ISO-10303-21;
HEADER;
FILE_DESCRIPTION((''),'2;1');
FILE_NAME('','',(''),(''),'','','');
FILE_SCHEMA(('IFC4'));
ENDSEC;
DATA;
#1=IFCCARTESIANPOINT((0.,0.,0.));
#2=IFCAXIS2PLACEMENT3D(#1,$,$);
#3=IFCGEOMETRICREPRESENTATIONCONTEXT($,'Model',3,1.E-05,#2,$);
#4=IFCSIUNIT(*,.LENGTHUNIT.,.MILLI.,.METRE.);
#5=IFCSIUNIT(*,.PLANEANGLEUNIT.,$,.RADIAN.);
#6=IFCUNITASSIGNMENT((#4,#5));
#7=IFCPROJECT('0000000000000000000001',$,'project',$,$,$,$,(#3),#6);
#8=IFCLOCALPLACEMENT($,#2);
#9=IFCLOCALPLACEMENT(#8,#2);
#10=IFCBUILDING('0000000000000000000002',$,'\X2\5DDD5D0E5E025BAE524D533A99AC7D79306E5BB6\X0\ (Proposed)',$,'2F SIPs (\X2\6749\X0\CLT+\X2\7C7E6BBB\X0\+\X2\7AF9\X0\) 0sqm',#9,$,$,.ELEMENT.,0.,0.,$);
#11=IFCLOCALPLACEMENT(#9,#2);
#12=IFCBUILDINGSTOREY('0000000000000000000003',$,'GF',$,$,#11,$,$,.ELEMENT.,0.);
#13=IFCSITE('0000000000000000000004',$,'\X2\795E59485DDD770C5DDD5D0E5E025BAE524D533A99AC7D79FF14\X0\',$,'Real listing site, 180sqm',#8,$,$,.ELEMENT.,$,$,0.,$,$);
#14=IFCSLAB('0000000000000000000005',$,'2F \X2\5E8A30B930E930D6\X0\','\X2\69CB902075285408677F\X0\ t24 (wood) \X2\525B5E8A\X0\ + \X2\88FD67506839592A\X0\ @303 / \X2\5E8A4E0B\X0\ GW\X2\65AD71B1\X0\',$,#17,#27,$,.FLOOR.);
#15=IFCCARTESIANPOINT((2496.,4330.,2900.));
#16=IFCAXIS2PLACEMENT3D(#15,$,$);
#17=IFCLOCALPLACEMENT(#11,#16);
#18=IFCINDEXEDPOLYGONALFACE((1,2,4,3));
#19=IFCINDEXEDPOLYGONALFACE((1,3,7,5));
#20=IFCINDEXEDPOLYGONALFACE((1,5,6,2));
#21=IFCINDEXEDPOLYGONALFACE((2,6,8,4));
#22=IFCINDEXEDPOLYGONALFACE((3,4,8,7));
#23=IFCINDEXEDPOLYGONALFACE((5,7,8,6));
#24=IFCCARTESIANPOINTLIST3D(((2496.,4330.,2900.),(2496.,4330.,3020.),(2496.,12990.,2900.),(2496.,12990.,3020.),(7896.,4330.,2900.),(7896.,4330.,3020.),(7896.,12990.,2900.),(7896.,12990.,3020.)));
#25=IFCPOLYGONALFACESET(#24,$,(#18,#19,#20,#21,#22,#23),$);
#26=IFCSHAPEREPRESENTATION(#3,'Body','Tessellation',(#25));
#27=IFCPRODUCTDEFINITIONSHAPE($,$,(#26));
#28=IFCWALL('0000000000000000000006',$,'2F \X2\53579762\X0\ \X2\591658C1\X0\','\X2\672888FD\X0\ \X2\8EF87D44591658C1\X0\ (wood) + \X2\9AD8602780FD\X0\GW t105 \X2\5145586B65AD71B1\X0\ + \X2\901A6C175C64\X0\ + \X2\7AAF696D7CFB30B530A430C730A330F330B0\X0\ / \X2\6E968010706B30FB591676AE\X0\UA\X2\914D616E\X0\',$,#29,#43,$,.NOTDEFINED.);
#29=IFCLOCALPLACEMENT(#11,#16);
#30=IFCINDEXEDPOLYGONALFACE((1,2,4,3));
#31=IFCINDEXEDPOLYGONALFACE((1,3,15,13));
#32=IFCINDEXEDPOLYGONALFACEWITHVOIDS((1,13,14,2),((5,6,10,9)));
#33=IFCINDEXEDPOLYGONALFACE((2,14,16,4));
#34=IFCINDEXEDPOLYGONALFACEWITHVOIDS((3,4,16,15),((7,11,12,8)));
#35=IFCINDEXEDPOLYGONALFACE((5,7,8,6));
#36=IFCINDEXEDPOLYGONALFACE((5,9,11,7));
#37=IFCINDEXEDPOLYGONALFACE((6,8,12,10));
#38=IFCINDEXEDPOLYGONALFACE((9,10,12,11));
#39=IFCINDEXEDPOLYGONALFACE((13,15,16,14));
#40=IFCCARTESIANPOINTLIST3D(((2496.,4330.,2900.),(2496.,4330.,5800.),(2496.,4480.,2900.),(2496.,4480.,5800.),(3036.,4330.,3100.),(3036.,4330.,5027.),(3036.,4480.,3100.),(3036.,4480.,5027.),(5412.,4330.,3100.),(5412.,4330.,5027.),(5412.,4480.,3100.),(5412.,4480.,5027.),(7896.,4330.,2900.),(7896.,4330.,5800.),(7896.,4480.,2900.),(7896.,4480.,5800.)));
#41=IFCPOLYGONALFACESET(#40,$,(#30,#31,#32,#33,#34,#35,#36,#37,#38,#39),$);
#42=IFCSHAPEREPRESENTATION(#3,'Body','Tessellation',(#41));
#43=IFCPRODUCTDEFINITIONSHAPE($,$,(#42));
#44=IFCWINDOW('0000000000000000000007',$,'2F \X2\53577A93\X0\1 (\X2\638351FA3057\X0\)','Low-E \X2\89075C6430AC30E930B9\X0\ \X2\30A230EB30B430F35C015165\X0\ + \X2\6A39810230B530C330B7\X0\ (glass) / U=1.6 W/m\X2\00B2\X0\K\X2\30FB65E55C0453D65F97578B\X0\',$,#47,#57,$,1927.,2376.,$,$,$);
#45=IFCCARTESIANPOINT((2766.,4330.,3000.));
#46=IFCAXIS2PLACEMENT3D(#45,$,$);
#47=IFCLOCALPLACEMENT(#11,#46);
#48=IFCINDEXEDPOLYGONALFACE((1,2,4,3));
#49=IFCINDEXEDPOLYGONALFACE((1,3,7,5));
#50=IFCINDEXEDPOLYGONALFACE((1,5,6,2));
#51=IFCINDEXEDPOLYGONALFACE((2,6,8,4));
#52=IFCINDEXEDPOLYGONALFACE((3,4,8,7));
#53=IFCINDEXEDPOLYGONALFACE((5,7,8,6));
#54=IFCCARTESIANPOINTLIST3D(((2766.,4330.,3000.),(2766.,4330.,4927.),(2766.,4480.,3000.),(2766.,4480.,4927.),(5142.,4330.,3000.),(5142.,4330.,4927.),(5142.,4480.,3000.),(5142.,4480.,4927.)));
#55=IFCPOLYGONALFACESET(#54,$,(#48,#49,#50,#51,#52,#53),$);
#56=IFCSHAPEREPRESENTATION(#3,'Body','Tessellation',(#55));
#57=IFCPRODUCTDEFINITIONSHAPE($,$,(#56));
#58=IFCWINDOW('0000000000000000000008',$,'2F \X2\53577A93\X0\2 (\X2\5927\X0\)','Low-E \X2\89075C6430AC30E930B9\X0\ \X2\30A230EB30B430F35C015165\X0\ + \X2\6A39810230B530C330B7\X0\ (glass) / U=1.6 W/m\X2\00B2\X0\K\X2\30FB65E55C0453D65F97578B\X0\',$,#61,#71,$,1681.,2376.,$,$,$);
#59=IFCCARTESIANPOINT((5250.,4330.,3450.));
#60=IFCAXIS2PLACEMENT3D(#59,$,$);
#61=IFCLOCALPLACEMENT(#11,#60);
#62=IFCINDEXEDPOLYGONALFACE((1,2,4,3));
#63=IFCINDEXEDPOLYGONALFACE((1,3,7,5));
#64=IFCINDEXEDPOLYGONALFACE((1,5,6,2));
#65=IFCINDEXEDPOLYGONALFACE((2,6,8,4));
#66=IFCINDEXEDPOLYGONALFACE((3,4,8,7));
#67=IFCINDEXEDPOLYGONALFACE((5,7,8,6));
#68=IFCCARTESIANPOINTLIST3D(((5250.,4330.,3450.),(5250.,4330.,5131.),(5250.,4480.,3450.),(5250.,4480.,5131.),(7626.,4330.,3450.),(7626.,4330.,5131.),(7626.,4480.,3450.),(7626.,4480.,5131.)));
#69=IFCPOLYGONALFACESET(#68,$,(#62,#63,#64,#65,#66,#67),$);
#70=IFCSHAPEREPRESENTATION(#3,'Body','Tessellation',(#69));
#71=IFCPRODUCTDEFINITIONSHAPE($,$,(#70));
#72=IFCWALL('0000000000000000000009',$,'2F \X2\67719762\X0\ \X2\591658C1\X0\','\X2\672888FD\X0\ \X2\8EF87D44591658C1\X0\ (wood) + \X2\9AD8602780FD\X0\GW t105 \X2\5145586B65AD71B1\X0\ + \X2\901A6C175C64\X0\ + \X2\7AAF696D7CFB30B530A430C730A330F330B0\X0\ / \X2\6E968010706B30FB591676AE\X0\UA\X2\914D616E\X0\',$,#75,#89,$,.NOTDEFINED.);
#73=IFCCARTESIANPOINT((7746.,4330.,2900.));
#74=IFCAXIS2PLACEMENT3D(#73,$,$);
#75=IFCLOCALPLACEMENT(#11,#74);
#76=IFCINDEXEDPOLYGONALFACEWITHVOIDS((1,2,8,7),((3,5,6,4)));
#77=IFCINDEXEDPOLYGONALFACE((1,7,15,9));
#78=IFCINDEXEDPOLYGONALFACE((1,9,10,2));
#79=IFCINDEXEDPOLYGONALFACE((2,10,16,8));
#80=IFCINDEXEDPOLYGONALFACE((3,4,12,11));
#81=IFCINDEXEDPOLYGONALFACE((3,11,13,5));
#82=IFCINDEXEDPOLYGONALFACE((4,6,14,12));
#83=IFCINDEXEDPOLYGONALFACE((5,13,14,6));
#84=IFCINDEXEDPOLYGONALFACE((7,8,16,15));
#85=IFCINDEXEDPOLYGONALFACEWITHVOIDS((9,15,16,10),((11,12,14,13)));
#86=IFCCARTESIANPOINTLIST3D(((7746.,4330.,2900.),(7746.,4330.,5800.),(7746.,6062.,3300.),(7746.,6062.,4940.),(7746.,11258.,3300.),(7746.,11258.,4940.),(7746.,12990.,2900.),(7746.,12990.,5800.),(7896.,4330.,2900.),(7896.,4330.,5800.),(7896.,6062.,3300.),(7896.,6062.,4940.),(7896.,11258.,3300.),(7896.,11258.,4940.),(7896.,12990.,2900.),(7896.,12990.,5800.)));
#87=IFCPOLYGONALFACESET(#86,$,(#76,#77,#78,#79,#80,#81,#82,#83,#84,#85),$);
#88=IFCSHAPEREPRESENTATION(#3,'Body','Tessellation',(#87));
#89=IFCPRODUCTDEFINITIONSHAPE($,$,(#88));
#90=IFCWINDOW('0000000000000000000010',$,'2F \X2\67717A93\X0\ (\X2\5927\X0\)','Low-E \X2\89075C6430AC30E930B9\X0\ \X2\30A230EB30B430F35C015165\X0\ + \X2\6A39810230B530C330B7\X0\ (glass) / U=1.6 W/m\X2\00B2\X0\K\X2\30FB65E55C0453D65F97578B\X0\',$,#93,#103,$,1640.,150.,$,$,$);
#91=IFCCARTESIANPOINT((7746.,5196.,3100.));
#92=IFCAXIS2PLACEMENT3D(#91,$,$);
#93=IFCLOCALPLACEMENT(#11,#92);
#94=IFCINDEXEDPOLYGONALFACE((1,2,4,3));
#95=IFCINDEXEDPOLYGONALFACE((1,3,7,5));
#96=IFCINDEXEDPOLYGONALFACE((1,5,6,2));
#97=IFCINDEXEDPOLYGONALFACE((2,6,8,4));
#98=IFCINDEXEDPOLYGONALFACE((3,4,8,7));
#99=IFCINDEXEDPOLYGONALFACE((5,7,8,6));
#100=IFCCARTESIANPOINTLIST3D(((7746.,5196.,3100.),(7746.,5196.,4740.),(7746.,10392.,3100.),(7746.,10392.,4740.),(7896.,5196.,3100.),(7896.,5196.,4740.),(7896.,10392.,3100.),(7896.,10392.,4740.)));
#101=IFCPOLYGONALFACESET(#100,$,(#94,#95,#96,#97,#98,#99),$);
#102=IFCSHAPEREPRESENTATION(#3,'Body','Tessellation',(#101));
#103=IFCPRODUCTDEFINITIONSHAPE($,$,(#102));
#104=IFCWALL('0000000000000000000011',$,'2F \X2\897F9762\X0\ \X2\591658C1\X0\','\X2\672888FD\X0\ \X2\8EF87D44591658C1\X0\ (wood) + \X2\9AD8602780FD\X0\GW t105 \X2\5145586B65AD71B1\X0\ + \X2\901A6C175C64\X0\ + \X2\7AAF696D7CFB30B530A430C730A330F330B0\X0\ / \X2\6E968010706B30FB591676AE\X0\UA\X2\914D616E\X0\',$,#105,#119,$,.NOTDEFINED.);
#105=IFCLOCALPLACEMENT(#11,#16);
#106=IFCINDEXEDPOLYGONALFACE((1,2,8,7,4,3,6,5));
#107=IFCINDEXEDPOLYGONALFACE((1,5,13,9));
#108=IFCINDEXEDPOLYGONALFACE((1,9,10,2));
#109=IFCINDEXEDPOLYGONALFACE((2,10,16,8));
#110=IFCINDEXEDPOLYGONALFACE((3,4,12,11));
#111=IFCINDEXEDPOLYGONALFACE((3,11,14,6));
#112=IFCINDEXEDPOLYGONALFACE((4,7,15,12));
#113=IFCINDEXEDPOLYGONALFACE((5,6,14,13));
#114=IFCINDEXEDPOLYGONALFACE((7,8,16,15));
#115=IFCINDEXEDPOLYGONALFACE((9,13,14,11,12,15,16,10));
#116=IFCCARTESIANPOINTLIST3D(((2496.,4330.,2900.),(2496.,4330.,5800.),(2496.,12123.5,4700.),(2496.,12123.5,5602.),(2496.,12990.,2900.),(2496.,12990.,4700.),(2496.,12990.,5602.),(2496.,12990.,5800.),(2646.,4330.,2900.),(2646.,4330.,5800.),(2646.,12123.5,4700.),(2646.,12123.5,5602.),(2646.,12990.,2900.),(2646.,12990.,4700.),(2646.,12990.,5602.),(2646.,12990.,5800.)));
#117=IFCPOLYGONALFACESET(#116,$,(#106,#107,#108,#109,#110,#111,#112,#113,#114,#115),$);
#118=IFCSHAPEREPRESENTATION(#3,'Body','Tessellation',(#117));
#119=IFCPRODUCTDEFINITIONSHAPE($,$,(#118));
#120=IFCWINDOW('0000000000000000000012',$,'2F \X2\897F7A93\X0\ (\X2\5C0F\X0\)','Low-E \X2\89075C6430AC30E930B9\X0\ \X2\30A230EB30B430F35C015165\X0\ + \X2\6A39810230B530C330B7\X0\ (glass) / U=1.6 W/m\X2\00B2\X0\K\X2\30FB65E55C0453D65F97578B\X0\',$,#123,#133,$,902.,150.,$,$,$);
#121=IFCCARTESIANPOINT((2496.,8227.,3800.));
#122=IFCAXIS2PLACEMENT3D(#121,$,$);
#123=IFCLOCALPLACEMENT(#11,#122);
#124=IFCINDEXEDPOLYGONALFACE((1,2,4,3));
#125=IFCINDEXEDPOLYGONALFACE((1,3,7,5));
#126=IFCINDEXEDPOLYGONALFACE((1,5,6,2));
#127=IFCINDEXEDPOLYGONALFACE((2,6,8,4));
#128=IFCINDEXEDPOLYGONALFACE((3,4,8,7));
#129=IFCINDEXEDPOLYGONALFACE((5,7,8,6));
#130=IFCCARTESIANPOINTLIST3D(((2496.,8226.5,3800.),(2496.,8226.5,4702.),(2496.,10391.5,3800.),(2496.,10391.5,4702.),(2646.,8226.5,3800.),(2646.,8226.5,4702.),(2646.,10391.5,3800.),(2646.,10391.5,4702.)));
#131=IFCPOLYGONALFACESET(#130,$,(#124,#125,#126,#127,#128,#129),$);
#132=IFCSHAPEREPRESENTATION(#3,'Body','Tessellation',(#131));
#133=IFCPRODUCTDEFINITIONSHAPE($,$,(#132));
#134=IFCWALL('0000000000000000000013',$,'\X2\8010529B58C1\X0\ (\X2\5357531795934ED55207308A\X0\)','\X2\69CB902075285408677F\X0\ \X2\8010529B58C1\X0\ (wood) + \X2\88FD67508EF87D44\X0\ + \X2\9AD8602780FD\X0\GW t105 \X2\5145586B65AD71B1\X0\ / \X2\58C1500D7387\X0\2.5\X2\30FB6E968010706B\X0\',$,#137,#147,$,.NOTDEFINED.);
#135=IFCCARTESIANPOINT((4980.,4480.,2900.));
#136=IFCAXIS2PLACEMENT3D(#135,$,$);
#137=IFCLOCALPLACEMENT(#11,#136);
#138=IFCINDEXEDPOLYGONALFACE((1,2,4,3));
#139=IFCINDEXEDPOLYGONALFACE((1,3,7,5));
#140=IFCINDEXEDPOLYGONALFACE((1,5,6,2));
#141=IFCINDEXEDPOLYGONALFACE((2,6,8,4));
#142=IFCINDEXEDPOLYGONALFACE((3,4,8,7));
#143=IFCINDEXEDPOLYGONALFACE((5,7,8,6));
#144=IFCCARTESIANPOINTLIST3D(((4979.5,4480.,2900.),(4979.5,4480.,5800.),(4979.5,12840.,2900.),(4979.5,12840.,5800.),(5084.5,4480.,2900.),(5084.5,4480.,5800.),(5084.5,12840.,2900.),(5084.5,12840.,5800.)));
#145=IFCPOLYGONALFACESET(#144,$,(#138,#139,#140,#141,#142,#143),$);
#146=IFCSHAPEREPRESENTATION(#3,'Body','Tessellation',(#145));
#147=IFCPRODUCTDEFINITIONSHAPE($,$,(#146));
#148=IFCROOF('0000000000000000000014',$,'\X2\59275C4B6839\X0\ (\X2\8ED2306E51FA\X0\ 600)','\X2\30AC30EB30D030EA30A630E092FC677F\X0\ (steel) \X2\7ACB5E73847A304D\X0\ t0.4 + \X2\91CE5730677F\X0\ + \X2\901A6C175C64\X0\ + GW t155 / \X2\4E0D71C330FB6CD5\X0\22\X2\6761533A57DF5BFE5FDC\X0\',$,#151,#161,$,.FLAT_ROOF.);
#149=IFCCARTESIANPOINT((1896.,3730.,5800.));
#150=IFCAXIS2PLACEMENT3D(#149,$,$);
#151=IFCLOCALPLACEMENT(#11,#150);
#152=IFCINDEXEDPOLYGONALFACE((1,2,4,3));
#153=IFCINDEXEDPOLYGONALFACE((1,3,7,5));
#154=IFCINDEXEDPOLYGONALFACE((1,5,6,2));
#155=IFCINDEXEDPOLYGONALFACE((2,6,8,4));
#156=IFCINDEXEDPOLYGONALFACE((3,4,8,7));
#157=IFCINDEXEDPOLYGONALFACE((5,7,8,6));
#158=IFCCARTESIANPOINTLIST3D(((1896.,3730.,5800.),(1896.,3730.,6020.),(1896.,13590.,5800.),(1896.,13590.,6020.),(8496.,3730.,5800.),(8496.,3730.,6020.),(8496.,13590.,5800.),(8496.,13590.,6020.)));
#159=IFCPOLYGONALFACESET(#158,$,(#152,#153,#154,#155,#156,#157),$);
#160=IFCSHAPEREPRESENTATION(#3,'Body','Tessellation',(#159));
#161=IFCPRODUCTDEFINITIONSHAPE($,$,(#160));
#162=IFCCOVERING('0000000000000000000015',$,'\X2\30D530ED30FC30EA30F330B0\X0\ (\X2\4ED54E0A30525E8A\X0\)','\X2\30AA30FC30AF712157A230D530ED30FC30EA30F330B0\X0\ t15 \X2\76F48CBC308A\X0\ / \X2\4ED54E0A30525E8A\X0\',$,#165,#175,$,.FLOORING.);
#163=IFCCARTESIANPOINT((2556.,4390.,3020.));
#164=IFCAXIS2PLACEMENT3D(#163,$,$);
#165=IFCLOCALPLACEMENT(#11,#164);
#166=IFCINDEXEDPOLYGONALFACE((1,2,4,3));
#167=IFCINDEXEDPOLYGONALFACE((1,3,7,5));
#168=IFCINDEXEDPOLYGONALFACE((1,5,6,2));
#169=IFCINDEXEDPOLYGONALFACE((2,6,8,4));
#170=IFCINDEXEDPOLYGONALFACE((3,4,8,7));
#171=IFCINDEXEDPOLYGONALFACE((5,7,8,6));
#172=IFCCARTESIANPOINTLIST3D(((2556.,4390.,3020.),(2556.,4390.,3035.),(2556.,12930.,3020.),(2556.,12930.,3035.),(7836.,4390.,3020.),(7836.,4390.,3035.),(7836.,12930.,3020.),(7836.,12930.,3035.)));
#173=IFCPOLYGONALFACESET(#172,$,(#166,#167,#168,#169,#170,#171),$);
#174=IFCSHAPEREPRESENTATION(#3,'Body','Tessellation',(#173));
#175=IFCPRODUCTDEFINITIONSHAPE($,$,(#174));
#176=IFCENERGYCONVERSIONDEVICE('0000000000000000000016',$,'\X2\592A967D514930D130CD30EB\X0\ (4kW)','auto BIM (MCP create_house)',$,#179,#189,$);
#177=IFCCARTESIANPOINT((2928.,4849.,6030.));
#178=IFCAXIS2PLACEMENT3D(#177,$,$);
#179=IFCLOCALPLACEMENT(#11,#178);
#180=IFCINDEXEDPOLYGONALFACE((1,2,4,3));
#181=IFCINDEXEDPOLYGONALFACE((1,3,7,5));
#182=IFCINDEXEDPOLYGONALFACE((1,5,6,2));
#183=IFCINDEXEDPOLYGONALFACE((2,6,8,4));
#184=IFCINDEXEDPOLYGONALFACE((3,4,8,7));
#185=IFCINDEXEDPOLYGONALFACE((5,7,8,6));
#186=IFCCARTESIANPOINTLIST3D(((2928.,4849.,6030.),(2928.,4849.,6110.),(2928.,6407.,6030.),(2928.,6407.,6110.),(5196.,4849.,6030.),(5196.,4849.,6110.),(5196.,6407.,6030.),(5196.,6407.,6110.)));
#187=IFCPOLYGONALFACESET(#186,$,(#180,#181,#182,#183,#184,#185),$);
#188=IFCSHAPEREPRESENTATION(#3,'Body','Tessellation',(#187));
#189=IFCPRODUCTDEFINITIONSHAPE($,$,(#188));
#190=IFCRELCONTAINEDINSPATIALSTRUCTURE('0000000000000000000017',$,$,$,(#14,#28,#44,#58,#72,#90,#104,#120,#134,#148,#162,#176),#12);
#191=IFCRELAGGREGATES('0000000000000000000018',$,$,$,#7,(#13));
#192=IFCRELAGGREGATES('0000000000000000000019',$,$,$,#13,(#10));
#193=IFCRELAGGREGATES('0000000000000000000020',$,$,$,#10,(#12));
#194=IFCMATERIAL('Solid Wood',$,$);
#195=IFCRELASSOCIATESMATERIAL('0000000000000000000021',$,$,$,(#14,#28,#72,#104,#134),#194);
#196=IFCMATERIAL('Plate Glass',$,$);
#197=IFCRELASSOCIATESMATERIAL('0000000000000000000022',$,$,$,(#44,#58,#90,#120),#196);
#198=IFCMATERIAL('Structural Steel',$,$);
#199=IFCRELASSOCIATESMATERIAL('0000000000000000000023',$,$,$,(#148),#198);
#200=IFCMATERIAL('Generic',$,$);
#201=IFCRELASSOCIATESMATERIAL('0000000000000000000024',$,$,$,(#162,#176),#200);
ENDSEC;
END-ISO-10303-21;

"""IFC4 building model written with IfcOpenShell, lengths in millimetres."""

from ifc_helpers import new_model, si_unit, frame, frame_2d, origin, place, context, project, spatial, rectangle, extrude, material, element, fill, save


model = new_model("IFC4")

# Units and contexts
model_context = context("Model", 3, precision=1e-05, world=origin())
ifc_project = project(units=[si_unit("LENGTHUNIT", "METRE", prefix="MILLI"), si_unit("PLANEANGLEUNIT", "RADIAN")], contexts=[model_context])

# Site, building, storey
site_placement = place(None, origin())
site = spatial("IfcSite", under=ifc_project, at=site_placement, Name="神奈川県川崎市宮前区馬絹４", ObjectType="Real listing site, 180sqm", CompositionType="ELEMENT", RefElevation=0.0)
building_placement = place(site_placement, origin())
building = spatial("IfcBuilding", under=site, at=building_placement, Name="川崎市宮前区馬絹の家 (Proposed)", ObjectType="2F SIPs (杉CLT+籾殻+竹) 0sqm", CompositionType="ELEMENT", ElevationOfRefHeight=0.0, ElevationOfTerrain=0.0)
storey_placement = place(building_placement, origin())
storey = spatial("IfcBuildingStorey", under=building, at=storey_placement, Name="GF", CompositionType="ELEMENT", Elevation=0.0)

# Slab
ifc_material_1 = material(Name="Solid Wood")
slab_placement = place(storey_placement, frame((2496.0, 4330.0, 2900.0)))
element("IfcSlab", 1, at=slab_placement, inside=storey, material=ifc_material_1, Name="2F 床スラブ", Description="構造用合板 t24 (wood) 剛床 + 製材根太 @303 / 床下 GW断熱", PredefinedType="FLOOR", context=model_context, shape_type="SweptSolid", body=[
    extrude(rectangle(XDim=5400.0, YDim=8660.0, at=frame_2d((2700.0, 4330.0))), frame((2496.0, 4330.0, 2900.0)), (0.0, 0.0, 1.0), 120.0),
])

# Wall, openings, windows
wall_1_placement = place(storey_placement, frame((2496.0, 4330.0, 2900.0)))
wall_1 = element("IfcWall", 2, at=wall_1_placement, inside=storey, material=ifc_material_1, Name="2F 南面 外壁", Description="木製 軸組外壁 (wood) + 高性能GW t105 充填断熱 + 通気層 + 窯業系サイディング / 準耐火・外皮UA配慮", PredefinedType="NOTDEFINED", context=model_context, shape_type="SweptSolid", body=[
    extrude(rectangle(XDim=5400.0, YDim=150.0, at=frame_2d((2700.0, 75.0))), frame((2496.0, 4330.0, 2900.0)), (0.0, 0.0, 1.0), 2900.0),
])
opening_1_placement = place(storey_placement, frame((2766.0, 4330.0, 3000.0)))
opening_1 = element("IfcOpeningElement", 3, at=opening_1_placement, cuts=wall_1, PredefinedType="NOTDEFINED", context=model_context, shape_type="SweptSolid", body=[
    extrude(rectangle(XDim=2376.0, YDim=150.0, at=frame_2d((1188.0, 75.0))), frame((2766.0, 4330.0, 3000.0)), (0.0, 0.0, 1.0), 1927.0),
])
opening_2_placement = place(storey_placement, frame((5250.0, 4330.0, 3450.0)))
opening_2 = element("IfcOpeningElement", 4, at=opening_2_placement, cuts=wall_1, PredefinedType="NOTDEFINED", context=model_context, shape_type="SweptSolid", body=[
    extrude(rectangle(XDim=2376.0, YDim=150.0, at=frame_2d((1188.0, 75.0))), frame((5250.0, 4330.0, 3450.0)), (0.0, 0.0, 1.0), 1681.0),
])
ifc_material_2 = material(Name="Plate Glass")
window_1_placement = place(storey_placement, frame((2766.0, 4330.0, 3000.0)))
window_1 = element("IfcWindow", 5, at=window_1_placement, inside=storey, material=ifc_material_2, Name="2F 南窓1 (掃出し)", Description="Low-E 複層ガラス アルゴン封入 + 樹脂サッシ (glass) / U=1.6 W/m²K・日射取得型", OverallHeight=1927.0, OverallWidth=2376.0, context=model_context, shape_type="SweptSolid", body=[
    extrude(rectangle(XDim=2376.0, YDim=150.0, at=frame_2d((1188.0, 75.0))), frame((2766.0, 4330.0, 3000.0)), (0.0, 0.0, 1.0), 1927.0),
])
fill(opening_1, window_1)
window_2_placement = place(storey_placement, frame((5250.0, 4330.0, 3450.0)))
window_2 = element("IfcWindow", 6, at=window_2_placement, inside=storey, material=ifc_material_2, Name="2F 南窓2 (大)", Description="Low-E 複層ガラス アルゴン封入 + 樹脂サッシ (glass) / U=1.6 W/m²K・日射取得型", OverallHeight=1681.0, OverallWidth=2376.0, context=model_context, shape_type="SweptSolid", body=[
    extrude(rectangle(XDim=2376.0, YDim=150.0, at=frame_2d((1188.0, 75.0))), frame((5250.0, 4330.0, 3450.0)), (0.0, 0.0, 1.0), 1681.0),
])
fill(opening_2, window_2)

# Walls, openings, windows
wall_2_placement = place(storey_placement, frame((7746.0, 4330.0, 2900.0)))
wall_2 = element("IfcWall", 7, at=wall_2_placement, inside=storey, material=ifc_material_1, Name="2F 東面 外壁", Description="木製 軸組外壁 (wood) + 高性能GW t105 充填断熱 + 通気層 + 窯業系サイディング / 準耐火・外皮UA配慮", PredefinedType="NOTDEFINED", context=model_context, shape_type="SweptSolid", body=[
    extrude(rectangle(XDim=150.0, YDim=8660.0, at=frame_2d((75.0, 4330.0))), frame((7746.0, 4330.0, 2900.0)), (0.0, 0.0, 1.0), 2900.0),
])
opening_3_placement = place(storey_placement, frame((7746.0, 5196.0, 3100.0)))
opening_3 = element("IfcOpeningElement", 8, at=opening_3_placement, cuts=wall_2, PredefinedType="NOTDEFINED", context=model_context, shape_type="SweptSolid", body=[
    extrude(rectangle(XDim=150.0, YDim=5196.0, at=frame_2d((75.0, 2598.0))), frame((7746.0, 5196.0, 3100.0)), (0.0, 0.0, 1.0), 1640.0),
])
window_3_placement = place(storey_placement, frame((7746.0, 5196.0, 3100.0)))
window_3 = element("IfcWindow", 9, at=window_3_placement, inside=storey, material=ifc_material_2, Name="2F 東窓 (大)", Description="Low-E 複層ガラス アルゴン封入 + 樹脂サッシ (glass) / U=1.6 W/m²K・日射取得型", OverallHeight=1640.0, OverallWidth=150.0, context=model_context, shape_type="SweptSolid", body=[
    extrude(rectangle(XDim=150.0, YDim=5196.0, at=frame_2d((75.0, 2598.0))), frame((7746.0, 5196.0, 3100.0)), (0.0, 0.0, 1.0), 1640.0),
])
fill(opening_3, window_3)
wall_3_placement = place(storey_placement, frame((2496.0, 4330.0, 2900.0)))
wall_3 = element("IfcWall", 10, at=wall_3_placement, inside=storey, material=ifc_material_1, Name="2F 西面 外壁", Description="木製 軸組外壁 (wood) + 高性能GW t105 充填断熱 + 通気層 + 窯業系サイディング / 準耐火・外皮UA配慮", PredefinedType="NOTDEFINED", context=model_context, shape_type="SweptSolid", body=[
    extrude(rectangle(XDim=150.0, YDim=8660.0, at=frame_2d((75.0, 4330.0))), frame((2496.0, 4330.0, 2900.0)), (0.0, 0.0, 1.0), 2900.0),
])
opening_4_placement = place(storey_placement, frame((2496.0, 8227.0, 3800.0)))
opening_4 = element("IfcOpeningElement", 11, at=opening_4_placement, cuts=wall_3, PredefinedType="NOTDEFINED", context=model_context, shape_type="SweptSolid", body=[
    extrude(rectangle(XDim=150.0, YDim=2165.0, at=frame_2d((75.0, 1082.0))), frame((2496.0, 8227.0, 3800.0)), (0.0, 0.0, 1.0), 902.0),
])
window_4_placement = place(storey_placement, frame((2496.0, 8227.0, 3800.0)))
window_4 = element("IfcWindow", 12, at=window_4_placement, inside=storey, material=ifc_material_2, Name="2F 西窓 (小)", Description="Low-E 複層ガラス アルゴン封入 + 樹脂サッシ (glass) / U=1.6 W/m²K・日射取得型", OverallHeight=902.0, OverallWidth=150.0, context=model_context, shape_type="SweptSolid", body=[
    extrude(rectangle(XDim=150.0, YDim=2165.0, at=frame_2d((75.0, 1082.0))), frame((2496.0, 8227.0, 3800.0)), (0.0, 0.0, 1.0), 902.0),
])
fill(opening_4, window_4)

# Wall
wall_4_placement = place(storey_placement, frame((4980.0, 4480.0, 2900.0)))
element("IfcWall", 13, at=wall_4_placement, inside=storey, material=ifc_material_1, Name="耐力壁 (南北間仕切り)", Description="構造用合板 耐力壁 (wood) + 製材軸組 + 高性能GW t105 充填断熱 / 壁倍率2.5・準耐火", PredefinedType="NOTDEFINED", context=model_context, shape_type="SweptSolid", body=[
    extrude(rectangle(XDim=105.0, YDim=8360.0, at=frame_2d((52.0, 4180.0))), frame((4980.0, 4480.0, 2900.0)), (0.0, 0.0, 1.0), 2900.0),
])

# Roof
ifc_material_3 = material(Name="Structural Steel")
roof_placement = place(storey_placement, frame((1896.0, 3730.0, 5800.0)))
element("IfcRoof", 14, at=roof_placement, inside=storey, material=ifc_material_3, Name="大屋根 (軒の出 600)", Description="ガルバリウム鋼板 (steel) 立平葺き t0.4 + 野地板 + 通気層 + GW t155 / 不燃・法22条区域対応", PredefinedType="FLAT_ROOF", context=model_context, shape_type="SweptSolid", body=[
    extrude(rectangle(XDim=6600.0, YDim=9860.0, at=frame_2d((3300.0, 4930.0))), frame((1896.0, 3730.0, 5800.0)), (0.0, 0.0, 1.0), 220.0),
])

# Covering
ifc_material_4 = material(Name="Generic")
covering_placement = place(storey_placement, frame((2556.0, 4390.0, 3020.0)))
element("IfcCovering", 15, at=covering_placement, inside=storey, material=ifc_material_4, Name="フローリング (仕上げ床)", Description="オーク無垢フローリング t15 直貼り / 仕上げ床", PredefinedType="FLOORING", context=model_context, shape_type="SweptSolid", body=[
    extrude(rectangle(XDim=5280.0, YDim=8540.0, at=frame_2d((2640.0, 4270.0))), frame((2556.0, 4390.0, 3020.0)), (0.0, 0.0, 1.0), 15.0),
])

# Energy conversion device
energy_conversion_device_placement = place(storey_placement, frame((2928.0, 4849.0, 6030.0)))
element("IfcEnergyConversionDevice", 16, at=energy_conversion_device_placement, inside=storey, material=ifc_material_4, Name="太陽光パネル (4kW)", Description="auto BIM (MCP create_house)", context=model_context, shape_type="SweptSolid", body=[
    extrude(rectangle(XDim=2268.0, YDim=1558.0, at=frame_2d((1134.0, 779.0))), frame((2928.0, 4849.0, 6030.0)), (0.0, 0.0, 1.0), 80.0),
])

save(model, "model.ifc")
